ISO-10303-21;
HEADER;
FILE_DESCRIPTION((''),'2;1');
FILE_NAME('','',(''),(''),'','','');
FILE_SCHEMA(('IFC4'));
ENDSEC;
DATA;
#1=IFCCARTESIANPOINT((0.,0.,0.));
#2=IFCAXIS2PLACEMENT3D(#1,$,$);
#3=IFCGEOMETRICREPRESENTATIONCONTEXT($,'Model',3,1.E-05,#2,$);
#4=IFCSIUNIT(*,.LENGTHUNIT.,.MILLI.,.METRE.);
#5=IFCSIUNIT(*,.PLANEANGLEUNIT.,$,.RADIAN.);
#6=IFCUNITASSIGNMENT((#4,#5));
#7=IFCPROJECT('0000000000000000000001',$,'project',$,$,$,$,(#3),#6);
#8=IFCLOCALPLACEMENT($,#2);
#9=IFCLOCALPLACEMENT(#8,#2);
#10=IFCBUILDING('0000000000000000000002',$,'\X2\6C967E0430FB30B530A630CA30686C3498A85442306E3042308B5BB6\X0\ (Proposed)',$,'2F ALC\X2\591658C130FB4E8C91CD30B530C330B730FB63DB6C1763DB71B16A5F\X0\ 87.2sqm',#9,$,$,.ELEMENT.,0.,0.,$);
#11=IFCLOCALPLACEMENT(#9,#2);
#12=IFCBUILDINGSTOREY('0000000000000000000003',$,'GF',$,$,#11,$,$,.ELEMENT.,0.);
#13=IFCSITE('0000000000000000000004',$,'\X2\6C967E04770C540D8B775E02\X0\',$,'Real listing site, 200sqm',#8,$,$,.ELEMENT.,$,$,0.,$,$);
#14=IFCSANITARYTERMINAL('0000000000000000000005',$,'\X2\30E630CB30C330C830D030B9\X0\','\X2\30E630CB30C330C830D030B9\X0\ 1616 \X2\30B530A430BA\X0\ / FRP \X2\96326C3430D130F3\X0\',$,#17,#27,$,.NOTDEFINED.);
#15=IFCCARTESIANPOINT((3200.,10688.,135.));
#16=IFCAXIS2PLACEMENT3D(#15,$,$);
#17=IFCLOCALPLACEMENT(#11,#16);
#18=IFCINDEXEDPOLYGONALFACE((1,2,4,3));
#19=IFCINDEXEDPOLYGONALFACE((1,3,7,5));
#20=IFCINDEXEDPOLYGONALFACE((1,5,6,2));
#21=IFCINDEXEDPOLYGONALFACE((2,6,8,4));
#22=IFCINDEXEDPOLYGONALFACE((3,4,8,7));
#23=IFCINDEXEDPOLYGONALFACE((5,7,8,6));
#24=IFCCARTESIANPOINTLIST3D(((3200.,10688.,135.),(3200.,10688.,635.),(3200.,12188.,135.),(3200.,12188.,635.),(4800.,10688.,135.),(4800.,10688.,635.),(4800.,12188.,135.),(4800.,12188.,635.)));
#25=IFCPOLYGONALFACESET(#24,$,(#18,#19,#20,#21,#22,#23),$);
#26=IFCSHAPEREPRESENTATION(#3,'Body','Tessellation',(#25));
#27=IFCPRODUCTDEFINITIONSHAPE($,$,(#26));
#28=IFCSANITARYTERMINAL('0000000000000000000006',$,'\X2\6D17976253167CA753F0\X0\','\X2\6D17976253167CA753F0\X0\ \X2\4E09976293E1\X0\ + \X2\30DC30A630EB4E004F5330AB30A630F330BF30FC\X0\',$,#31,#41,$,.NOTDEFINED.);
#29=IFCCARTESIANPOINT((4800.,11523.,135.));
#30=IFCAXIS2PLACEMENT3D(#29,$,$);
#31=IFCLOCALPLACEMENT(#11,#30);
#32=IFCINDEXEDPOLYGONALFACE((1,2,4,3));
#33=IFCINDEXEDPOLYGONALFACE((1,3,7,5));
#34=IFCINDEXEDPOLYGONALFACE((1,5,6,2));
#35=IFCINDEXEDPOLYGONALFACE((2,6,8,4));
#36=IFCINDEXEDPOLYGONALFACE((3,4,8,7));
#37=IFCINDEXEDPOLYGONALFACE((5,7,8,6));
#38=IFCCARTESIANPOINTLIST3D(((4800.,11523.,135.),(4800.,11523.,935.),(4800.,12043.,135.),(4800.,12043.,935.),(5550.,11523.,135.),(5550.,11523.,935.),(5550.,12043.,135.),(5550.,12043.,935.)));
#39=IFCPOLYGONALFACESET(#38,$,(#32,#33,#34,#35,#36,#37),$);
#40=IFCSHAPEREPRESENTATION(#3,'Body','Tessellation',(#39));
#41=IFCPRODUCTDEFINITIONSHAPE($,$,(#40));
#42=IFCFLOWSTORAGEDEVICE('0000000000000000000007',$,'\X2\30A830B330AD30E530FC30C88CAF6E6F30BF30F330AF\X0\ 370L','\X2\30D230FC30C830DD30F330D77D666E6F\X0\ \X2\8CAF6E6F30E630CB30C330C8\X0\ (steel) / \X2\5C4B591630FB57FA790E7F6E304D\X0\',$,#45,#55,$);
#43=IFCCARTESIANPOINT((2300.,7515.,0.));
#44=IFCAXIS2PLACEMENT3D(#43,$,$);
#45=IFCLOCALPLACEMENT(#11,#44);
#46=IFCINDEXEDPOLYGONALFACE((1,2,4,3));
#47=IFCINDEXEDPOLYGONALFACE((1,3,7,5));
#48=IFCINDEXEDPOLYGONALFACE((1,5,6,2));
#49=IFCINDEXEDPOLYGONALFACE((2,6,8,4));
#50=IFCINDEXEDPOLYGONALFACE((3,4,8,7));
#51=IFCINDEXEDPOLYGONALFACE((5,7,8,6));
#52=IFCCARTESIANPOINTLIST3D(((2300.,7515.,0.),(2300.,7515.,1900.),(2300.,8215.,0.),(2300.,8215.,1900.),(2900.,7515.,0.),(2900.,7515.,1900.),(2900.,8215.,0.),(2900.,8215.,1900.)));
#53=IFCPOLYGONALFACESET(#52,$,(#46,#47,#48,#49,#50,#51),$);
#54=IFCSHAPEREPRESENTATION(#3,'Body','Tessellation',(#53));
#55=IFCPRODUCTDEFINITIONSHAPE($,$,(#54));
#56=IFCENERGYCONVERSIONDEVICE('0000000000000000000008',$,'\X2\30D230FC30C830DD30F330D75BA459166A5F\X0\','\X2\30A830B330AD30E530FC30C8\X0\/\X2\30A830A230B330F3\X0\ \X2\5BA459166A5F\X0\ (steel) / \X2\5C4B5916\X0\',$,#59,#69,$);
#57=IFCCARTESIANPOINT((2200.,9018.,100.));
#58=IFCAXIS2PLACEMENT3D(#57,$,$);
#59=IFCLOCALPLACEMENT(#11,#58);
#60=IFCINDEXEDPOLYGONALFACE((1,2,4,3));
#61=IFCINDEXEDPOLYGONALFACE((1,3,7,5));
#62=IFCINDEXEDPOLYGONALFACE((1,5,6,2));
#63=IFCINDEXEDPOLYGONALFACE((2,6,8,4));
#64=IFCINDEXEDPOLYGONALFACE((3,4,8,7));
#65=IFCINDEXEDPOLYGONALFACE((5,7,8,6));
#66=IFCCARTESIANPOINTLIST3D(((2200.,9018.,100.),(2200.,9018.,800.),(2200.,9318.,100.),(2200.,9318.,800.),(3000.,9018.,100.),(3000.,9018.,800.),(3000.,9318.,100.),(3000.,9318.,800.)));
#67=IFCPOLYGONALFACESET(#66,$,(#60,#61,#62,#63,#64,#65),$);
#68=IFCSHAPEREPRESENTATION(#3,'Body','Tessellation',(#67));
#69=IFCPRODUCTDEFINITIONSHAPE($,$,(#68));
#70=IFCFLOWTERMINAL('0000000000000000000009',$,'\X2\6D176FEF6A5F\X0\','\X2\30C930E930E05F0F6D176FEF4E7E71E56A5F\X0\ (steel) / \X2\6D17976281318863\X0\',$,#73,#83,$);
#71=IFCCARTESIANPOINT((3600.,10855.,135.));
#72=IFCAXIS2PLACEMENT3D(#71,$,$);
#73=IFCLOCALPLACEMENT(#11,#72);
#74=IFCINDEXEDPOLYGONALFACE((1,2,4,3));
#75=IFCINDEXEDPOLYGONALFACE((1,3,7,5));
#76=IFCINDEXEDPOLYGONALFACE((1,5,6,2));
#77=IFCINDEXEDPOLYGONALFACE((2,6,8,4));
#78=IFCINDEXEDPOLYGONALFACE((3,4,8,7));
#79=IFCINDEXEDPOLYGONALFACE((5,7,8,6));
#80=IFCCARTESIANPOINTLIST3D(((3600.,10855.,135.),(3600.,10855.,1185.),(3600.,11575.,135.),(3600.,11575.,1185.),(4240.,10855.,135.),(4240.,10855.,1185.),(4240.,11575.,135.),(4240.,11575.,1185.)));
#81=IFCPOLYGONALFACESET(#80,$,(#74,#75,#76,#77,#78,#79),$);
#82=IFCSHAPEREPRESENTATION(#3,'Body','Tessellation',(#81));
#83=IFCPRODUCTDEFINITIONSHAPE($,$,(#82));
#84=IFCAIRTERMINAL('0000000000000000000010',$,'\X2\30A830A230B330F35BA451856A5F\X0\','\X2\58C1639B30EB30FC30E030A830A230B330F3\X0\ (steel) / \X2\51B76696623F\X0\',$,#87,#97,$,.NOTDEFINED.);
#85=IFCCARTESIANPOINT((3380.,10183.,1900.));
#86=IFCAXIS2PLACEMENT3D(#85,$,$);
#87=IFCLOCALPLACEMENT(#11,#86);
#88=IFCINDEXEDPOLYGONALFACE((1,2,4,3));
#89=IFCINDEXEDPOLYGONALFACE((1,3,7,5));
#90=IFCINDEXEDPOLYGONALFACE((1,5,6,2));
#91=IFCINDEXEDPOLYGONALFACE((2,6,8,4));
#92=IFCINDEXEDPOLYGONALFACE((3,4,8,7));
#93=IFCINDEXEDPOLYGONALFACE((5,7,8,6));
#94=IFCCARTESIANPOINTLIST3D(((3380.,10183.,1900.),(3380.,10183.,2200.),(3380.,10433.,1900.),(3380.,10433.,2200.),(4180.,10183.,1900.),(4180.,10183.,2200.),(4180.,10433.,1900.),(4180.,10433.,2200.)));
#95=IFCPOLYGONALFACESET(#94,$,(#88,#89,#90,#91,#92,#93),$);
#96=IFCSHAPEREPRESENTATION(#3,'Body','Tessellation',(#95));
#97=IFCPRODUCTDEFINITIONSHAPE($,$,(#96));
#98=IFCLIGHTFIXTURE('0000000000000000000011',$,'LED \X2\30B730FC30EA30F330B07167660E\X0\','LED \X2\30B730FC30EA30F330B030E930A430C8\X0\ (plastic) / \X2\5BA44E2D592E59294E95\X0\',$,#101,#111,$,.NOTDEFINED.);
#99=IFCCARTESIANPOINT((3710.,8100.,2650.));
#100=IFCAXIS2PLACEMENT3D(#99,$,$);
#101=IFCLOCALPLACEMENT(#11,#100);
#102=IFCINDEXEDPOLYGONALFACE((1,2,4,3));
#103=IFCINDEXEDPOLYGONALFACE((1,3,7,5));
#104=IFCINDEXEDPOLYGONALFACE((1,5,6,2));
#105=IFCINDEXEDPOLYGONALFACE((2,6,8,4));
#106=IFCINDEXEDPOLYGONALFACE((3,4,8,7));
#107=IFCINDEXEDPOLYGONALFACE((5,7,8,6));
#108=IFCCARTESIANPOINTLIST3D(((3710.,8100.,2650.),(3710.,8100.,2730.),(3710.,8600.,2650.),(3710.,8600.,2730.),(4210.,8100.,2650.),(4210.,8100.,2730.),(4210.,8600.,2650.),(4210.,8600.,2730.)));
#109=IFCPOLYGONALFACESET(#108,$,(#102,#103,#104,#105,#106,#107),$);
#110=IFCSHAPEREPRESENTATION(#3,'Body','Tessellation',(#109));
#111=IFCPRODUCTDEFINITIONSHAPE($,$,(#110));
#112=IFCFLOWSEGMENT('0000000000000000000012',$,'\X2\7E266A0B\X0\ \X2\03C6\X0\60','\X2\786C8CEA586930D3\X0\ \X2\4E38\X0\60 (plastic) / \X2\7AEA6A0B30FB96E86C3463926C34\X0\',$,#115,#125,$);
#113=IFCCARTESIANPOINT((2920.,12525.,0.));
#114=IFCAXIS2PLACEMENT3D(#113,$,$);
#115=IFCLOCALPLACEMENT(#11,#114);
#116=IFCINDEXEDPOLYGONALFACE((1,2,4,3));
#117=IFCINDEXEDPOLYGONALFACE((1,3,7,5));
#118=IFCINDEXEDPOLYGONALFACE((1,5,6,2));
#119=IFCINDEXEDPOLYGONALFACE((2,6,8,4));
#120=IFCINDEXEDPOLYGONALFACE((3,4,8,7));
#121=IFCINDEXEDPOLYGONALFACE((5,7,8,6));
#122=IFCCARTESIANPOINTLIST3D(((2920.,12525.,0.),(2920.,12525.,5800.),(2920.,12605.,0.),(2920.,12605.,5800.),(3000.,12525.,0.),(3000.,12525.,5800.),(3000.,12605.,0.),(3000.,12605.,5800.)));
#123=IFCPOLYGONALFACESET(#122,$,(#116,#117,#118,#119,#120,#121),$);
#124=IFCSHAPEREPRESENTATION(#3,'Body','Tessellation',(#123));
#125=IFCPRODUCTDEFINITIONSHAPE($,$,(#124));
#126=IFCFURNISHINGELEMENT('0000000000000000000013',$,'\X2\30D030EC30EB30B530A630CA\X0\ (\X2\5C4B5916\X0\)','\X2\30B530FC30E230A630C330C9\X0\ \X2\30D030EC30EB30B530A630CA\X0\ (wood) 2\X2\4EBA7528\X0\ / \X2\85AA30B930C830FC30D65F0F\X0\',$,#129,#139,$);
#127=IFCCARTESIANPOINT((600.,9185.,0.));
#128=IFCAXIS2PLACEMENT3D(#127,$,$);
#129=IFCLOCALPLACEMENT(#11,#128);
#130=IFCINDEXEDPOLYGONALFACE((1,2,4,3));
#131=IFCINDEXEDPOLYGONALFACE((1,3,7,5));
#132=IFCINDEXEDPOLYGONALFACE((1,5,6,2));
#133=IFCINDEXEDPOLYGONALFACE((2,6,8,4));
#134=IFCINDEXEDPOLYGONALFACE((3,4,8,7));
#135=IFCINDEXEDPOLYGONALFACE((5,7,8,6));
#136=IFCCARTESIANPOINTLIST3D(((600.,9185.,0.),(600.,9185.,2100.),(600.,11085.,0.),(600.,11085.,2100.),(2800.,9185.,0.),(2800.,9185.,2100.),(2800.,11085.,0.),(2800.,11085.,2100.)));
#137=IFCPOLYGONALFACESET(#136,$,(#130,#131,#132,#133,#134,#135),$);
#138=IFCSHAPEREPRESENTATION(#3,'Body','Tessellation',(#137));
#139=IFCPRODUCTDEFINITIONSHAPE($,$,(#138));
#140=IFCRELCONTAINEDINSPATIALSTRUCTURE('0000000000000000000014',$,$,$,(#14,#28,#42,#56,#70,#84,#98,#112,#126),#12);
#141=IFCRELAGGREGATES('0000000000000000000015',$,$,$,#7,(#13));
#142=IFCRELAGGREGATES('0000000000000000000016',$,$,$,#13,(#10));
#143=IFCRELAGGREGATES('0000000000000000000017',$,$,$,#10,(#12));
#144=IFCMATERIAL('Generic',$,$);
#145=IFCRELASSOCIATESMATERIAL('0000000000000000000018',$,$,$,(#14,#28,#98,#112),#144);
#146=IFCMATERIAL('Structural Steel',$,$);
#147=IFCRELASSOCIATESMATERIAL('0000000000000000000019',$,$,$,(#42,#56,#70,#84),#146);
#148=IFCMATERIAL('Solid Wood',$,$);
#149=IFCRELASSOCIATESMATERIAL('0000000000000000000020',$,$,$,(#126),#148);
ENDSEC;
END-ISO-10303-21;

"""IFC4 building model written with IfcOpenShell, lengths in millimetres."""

from ifc_helpers import new_model, si_unit, frame, frame_2d, origin, place, context, project, spatial, rectangle, extrude, material, element, save


model = new_model("IFC4")

# Units and contexts
model_context = context("Model", 3, precision=1e-05, world=origin())
ifc_project = project(units=[si_unit("LENGTHUNIT", "METRE", prefix="MILLI"), si_unit("PLANEANGLEUNIT", "RADIAN")], contexts=[model_context])

# Site, building, storey
site_placement = place(None, origin())
site = spatial("IfcSite", under=ifc_project, at=site_placement, Name="沖縄県名護市", ObjectType="Real listing site, 200sqm", CompositionType="ELEMENT", RefElevation=0.0)
building_placement = place(site_placement, origin())
building = spatial("IfcBuilding", under=site, at=building_placement, Name="沖縄・サウナと水風呂のある家 (Proposed)", ObjectType="2F ALC外壁・二重サッシ・換気換熱機 87.2sqm", CompositionType="ELEMENT", ElevationOfRefHeight=0.0, ElevationOfTerrain=0.0)
storey_placement = place(building_placement, origin())
storey = spatial("IfcBuildingStorey", under=building, at=storey_placement, Name="GF", CompositionType="ELEMENT", Elevation=0.0)

# Shared definitions
ifc_material_1 = material(Name="Solid Wood")

# Shared definitions
ifc_material_2 = material(Name="Generic")

# Sanitary terminals
sanitary_terminal_1_placement = place(storey_placement, frame((3200.0, 10688.0, 135.0)))
element("IfcSanitaryTerminal", 1, at=sanitary_terminal_1_placement, inside=storey, material=ifc_material_2, Name="ユニットバス", Description="ユニットバス 1616 サイズ / FRP 防水パン", PredefinedType="NOTDEFINED", context=model_context, shape_type="SweptSolid", body=[
    extrude(rectangle(XDim=1600.0, YDim=1500.0, at=frame_2d((800.0, 750.0))), frame((3200.0, 10688.0, 135.0)), (0.0, 0.0, 1.0), 500.0),
])
sanitary_terminal_2_placement = place(storey_placement, frame((4800.0, 11523.0, 135.0)))
element("IfcSanitaryTerminal", 2, at=sanitary_terminal_2_placement, inside=storey, material=ifc_material_2, Name="洗面化粧台", Description="洗面化粧台 三面鏡 + ボウル一体カウンター", PredefinedType="NOTDEFINED", context=model_context, shape_type="SweptSolid", body=[
    extrude(rectangle(XDim=750.0, YDim=520.0, at=frame_2d((375.0, 260.0))), frame((4800.0, 11523.0, 135.0)), (0.0, 0.0, 1.0), 800.0),
])

# Flow storage device
ifc_material_3 = material(Name="Structural Steel")
flow_storage_device_placement = place(storey_placement, frame((2300.0, 7515.0, 0.0)))
element("IfcFlowStorageDevice", 3, at=flow_storage_device_placement, inside=storey, material=ifc_material_3, Name="エコキュート貯湯タンク 370L", Description="ヒートポンプ給湯 貯湯ユニット (steel) / 屋外・基礎置き", context=model_context, shape_type="SweptSolid", body=[
    extrude(rectangle(XDim=600.0, YDim=700.0, at=frame_2d((300.0, 350.0))), frame((2300.0, 7515.0, 0.0)), (0.0, 0.0, 1.0), 1900.0),
])

# Energy conversion device
energy_conversion_device_placement = place(storey_placement, frame((2200.0, 9018.0, 100.0)))
element("IfcEnergyConversionDevice", 4, at=energy_conversion_device_placement, inside=storey, material=ifc_material_3, Name="ヒートポンプ室外機", Description="エコキュート/エアコン 室外機 (steel) / 屋外", context=model_context, shape_type="SweptSolid", body=[
    extrude(rectangle(XDim=800.0, YDim=300.0, at=frame_2d((400.0, 150.0))), frame((2200.0, 9018.0, 100.0)), (0.0, 0.0, 1.0), 700.0),
])

# Flow terminal
flow_terminal_placement = place(storey_placement, frame((3600.0, 10855.0, 135.0)))
element("IfcFlowTerminal", 5, at=flow_terminal_placement, inside=storey, material=ifc_material_3, Name="洗濯機", Description="ドラム式洗濯乾燥機 (steel) / 洗面脱衣", context=model_context, shape_type="SweptSolid", body=[
    extrude(rectangle(XDim=640.0, YDim=720.0, at=frame_2d((320.0, 360.0))), frame((3600.0, 10855.0, 135.0)), (0.0, 0.0, 1.0), 1050.0),
])

# Air terminal
air_terminal_placement = place(storey_placement, frame((3380.0, 10183.0, 1900.0)))
element("IfcAirTerminal", 6, at=air_terminal_placement, inside=storey, material=ifc_material_3, Name="エアコン室内機", Description="壁掛ルームエアコン (steel) / 冷暖房", PredefinedType="NOTDEFINED", context=model_context, shape_type="SweptSolid", body=[
    extrude(rectangle(XDim=800.0, YDim=250.0, at=frame_2d((400.0, 125.0))), frame((3380.0, 10183.0, 1900.0)), (0.0, 0.0, 1.0), 300.0),
])

# Light fixture
light_fixture_placement = place(storey_placement, frame((3710.0, 8100.0, 2650.0)))
element("IfcLightFixture", 7, at=light_fixture_placement, inside=storey, material=ifc_material_2, Name="LED シーリング照明", Description="LED シーリングライト (plastic) / 室中央天井", PredefinedType="NOTDEFINED", context=model_context, shape_type="SweptSolid", body=[
    extrude(rectangle(XDim=500.0, YDim=500.0, at=frame_2d((250.0, 250.0))), frame((3710.0, 8100.0, 2650.0)), (0.0, 0.0, 1.0), 80.0),
])

# Flow segment
flow_segment_placement = place(storey_placement, frame((2920.0, 12525.0, 0.0)))
element("IfcFlowSegment", 8, at=flow_segment_placement, inside=storey, material=ifc_material_2, Name="縦樋 φ60", Description="硬質塩ビ 丸60 (plastic) / 竪樋・雨水排水", context=model_context, shape_type="SweptSolid", body=[
    extrude(rectangle(XDim=80.0, YDim=80.0, at=frame_2d((40.0, 40.0))), frame((2920.0, 12525.0, 0.0)), (0.0, 0.0, 1.0), 5800.0),
])

# Furnishing element
furnishing_placement = place(storey_placement, frame((600.0, 9185.0, 0.0)))
element("IfcFurnishingElement", 9, at=furnishing_placement, inside=storey, material=ifc_material_1, Name="バレルサウナ (屋外)", Description="サーモウッド バレルサウナ (wood) 2人用 / 薪ストーブ式", context=model_context, shape_type="SweptSolid", body=[
    extrude(rectangle(XDim=2200.0, YDim=1900.0, at=frame_2d((1100.0, 950.0))), frame((600.0, 9185.0, 0.0)), (0.0, 0.0, 1.0), 2100.0),
])

save(model, "model.ifc")
